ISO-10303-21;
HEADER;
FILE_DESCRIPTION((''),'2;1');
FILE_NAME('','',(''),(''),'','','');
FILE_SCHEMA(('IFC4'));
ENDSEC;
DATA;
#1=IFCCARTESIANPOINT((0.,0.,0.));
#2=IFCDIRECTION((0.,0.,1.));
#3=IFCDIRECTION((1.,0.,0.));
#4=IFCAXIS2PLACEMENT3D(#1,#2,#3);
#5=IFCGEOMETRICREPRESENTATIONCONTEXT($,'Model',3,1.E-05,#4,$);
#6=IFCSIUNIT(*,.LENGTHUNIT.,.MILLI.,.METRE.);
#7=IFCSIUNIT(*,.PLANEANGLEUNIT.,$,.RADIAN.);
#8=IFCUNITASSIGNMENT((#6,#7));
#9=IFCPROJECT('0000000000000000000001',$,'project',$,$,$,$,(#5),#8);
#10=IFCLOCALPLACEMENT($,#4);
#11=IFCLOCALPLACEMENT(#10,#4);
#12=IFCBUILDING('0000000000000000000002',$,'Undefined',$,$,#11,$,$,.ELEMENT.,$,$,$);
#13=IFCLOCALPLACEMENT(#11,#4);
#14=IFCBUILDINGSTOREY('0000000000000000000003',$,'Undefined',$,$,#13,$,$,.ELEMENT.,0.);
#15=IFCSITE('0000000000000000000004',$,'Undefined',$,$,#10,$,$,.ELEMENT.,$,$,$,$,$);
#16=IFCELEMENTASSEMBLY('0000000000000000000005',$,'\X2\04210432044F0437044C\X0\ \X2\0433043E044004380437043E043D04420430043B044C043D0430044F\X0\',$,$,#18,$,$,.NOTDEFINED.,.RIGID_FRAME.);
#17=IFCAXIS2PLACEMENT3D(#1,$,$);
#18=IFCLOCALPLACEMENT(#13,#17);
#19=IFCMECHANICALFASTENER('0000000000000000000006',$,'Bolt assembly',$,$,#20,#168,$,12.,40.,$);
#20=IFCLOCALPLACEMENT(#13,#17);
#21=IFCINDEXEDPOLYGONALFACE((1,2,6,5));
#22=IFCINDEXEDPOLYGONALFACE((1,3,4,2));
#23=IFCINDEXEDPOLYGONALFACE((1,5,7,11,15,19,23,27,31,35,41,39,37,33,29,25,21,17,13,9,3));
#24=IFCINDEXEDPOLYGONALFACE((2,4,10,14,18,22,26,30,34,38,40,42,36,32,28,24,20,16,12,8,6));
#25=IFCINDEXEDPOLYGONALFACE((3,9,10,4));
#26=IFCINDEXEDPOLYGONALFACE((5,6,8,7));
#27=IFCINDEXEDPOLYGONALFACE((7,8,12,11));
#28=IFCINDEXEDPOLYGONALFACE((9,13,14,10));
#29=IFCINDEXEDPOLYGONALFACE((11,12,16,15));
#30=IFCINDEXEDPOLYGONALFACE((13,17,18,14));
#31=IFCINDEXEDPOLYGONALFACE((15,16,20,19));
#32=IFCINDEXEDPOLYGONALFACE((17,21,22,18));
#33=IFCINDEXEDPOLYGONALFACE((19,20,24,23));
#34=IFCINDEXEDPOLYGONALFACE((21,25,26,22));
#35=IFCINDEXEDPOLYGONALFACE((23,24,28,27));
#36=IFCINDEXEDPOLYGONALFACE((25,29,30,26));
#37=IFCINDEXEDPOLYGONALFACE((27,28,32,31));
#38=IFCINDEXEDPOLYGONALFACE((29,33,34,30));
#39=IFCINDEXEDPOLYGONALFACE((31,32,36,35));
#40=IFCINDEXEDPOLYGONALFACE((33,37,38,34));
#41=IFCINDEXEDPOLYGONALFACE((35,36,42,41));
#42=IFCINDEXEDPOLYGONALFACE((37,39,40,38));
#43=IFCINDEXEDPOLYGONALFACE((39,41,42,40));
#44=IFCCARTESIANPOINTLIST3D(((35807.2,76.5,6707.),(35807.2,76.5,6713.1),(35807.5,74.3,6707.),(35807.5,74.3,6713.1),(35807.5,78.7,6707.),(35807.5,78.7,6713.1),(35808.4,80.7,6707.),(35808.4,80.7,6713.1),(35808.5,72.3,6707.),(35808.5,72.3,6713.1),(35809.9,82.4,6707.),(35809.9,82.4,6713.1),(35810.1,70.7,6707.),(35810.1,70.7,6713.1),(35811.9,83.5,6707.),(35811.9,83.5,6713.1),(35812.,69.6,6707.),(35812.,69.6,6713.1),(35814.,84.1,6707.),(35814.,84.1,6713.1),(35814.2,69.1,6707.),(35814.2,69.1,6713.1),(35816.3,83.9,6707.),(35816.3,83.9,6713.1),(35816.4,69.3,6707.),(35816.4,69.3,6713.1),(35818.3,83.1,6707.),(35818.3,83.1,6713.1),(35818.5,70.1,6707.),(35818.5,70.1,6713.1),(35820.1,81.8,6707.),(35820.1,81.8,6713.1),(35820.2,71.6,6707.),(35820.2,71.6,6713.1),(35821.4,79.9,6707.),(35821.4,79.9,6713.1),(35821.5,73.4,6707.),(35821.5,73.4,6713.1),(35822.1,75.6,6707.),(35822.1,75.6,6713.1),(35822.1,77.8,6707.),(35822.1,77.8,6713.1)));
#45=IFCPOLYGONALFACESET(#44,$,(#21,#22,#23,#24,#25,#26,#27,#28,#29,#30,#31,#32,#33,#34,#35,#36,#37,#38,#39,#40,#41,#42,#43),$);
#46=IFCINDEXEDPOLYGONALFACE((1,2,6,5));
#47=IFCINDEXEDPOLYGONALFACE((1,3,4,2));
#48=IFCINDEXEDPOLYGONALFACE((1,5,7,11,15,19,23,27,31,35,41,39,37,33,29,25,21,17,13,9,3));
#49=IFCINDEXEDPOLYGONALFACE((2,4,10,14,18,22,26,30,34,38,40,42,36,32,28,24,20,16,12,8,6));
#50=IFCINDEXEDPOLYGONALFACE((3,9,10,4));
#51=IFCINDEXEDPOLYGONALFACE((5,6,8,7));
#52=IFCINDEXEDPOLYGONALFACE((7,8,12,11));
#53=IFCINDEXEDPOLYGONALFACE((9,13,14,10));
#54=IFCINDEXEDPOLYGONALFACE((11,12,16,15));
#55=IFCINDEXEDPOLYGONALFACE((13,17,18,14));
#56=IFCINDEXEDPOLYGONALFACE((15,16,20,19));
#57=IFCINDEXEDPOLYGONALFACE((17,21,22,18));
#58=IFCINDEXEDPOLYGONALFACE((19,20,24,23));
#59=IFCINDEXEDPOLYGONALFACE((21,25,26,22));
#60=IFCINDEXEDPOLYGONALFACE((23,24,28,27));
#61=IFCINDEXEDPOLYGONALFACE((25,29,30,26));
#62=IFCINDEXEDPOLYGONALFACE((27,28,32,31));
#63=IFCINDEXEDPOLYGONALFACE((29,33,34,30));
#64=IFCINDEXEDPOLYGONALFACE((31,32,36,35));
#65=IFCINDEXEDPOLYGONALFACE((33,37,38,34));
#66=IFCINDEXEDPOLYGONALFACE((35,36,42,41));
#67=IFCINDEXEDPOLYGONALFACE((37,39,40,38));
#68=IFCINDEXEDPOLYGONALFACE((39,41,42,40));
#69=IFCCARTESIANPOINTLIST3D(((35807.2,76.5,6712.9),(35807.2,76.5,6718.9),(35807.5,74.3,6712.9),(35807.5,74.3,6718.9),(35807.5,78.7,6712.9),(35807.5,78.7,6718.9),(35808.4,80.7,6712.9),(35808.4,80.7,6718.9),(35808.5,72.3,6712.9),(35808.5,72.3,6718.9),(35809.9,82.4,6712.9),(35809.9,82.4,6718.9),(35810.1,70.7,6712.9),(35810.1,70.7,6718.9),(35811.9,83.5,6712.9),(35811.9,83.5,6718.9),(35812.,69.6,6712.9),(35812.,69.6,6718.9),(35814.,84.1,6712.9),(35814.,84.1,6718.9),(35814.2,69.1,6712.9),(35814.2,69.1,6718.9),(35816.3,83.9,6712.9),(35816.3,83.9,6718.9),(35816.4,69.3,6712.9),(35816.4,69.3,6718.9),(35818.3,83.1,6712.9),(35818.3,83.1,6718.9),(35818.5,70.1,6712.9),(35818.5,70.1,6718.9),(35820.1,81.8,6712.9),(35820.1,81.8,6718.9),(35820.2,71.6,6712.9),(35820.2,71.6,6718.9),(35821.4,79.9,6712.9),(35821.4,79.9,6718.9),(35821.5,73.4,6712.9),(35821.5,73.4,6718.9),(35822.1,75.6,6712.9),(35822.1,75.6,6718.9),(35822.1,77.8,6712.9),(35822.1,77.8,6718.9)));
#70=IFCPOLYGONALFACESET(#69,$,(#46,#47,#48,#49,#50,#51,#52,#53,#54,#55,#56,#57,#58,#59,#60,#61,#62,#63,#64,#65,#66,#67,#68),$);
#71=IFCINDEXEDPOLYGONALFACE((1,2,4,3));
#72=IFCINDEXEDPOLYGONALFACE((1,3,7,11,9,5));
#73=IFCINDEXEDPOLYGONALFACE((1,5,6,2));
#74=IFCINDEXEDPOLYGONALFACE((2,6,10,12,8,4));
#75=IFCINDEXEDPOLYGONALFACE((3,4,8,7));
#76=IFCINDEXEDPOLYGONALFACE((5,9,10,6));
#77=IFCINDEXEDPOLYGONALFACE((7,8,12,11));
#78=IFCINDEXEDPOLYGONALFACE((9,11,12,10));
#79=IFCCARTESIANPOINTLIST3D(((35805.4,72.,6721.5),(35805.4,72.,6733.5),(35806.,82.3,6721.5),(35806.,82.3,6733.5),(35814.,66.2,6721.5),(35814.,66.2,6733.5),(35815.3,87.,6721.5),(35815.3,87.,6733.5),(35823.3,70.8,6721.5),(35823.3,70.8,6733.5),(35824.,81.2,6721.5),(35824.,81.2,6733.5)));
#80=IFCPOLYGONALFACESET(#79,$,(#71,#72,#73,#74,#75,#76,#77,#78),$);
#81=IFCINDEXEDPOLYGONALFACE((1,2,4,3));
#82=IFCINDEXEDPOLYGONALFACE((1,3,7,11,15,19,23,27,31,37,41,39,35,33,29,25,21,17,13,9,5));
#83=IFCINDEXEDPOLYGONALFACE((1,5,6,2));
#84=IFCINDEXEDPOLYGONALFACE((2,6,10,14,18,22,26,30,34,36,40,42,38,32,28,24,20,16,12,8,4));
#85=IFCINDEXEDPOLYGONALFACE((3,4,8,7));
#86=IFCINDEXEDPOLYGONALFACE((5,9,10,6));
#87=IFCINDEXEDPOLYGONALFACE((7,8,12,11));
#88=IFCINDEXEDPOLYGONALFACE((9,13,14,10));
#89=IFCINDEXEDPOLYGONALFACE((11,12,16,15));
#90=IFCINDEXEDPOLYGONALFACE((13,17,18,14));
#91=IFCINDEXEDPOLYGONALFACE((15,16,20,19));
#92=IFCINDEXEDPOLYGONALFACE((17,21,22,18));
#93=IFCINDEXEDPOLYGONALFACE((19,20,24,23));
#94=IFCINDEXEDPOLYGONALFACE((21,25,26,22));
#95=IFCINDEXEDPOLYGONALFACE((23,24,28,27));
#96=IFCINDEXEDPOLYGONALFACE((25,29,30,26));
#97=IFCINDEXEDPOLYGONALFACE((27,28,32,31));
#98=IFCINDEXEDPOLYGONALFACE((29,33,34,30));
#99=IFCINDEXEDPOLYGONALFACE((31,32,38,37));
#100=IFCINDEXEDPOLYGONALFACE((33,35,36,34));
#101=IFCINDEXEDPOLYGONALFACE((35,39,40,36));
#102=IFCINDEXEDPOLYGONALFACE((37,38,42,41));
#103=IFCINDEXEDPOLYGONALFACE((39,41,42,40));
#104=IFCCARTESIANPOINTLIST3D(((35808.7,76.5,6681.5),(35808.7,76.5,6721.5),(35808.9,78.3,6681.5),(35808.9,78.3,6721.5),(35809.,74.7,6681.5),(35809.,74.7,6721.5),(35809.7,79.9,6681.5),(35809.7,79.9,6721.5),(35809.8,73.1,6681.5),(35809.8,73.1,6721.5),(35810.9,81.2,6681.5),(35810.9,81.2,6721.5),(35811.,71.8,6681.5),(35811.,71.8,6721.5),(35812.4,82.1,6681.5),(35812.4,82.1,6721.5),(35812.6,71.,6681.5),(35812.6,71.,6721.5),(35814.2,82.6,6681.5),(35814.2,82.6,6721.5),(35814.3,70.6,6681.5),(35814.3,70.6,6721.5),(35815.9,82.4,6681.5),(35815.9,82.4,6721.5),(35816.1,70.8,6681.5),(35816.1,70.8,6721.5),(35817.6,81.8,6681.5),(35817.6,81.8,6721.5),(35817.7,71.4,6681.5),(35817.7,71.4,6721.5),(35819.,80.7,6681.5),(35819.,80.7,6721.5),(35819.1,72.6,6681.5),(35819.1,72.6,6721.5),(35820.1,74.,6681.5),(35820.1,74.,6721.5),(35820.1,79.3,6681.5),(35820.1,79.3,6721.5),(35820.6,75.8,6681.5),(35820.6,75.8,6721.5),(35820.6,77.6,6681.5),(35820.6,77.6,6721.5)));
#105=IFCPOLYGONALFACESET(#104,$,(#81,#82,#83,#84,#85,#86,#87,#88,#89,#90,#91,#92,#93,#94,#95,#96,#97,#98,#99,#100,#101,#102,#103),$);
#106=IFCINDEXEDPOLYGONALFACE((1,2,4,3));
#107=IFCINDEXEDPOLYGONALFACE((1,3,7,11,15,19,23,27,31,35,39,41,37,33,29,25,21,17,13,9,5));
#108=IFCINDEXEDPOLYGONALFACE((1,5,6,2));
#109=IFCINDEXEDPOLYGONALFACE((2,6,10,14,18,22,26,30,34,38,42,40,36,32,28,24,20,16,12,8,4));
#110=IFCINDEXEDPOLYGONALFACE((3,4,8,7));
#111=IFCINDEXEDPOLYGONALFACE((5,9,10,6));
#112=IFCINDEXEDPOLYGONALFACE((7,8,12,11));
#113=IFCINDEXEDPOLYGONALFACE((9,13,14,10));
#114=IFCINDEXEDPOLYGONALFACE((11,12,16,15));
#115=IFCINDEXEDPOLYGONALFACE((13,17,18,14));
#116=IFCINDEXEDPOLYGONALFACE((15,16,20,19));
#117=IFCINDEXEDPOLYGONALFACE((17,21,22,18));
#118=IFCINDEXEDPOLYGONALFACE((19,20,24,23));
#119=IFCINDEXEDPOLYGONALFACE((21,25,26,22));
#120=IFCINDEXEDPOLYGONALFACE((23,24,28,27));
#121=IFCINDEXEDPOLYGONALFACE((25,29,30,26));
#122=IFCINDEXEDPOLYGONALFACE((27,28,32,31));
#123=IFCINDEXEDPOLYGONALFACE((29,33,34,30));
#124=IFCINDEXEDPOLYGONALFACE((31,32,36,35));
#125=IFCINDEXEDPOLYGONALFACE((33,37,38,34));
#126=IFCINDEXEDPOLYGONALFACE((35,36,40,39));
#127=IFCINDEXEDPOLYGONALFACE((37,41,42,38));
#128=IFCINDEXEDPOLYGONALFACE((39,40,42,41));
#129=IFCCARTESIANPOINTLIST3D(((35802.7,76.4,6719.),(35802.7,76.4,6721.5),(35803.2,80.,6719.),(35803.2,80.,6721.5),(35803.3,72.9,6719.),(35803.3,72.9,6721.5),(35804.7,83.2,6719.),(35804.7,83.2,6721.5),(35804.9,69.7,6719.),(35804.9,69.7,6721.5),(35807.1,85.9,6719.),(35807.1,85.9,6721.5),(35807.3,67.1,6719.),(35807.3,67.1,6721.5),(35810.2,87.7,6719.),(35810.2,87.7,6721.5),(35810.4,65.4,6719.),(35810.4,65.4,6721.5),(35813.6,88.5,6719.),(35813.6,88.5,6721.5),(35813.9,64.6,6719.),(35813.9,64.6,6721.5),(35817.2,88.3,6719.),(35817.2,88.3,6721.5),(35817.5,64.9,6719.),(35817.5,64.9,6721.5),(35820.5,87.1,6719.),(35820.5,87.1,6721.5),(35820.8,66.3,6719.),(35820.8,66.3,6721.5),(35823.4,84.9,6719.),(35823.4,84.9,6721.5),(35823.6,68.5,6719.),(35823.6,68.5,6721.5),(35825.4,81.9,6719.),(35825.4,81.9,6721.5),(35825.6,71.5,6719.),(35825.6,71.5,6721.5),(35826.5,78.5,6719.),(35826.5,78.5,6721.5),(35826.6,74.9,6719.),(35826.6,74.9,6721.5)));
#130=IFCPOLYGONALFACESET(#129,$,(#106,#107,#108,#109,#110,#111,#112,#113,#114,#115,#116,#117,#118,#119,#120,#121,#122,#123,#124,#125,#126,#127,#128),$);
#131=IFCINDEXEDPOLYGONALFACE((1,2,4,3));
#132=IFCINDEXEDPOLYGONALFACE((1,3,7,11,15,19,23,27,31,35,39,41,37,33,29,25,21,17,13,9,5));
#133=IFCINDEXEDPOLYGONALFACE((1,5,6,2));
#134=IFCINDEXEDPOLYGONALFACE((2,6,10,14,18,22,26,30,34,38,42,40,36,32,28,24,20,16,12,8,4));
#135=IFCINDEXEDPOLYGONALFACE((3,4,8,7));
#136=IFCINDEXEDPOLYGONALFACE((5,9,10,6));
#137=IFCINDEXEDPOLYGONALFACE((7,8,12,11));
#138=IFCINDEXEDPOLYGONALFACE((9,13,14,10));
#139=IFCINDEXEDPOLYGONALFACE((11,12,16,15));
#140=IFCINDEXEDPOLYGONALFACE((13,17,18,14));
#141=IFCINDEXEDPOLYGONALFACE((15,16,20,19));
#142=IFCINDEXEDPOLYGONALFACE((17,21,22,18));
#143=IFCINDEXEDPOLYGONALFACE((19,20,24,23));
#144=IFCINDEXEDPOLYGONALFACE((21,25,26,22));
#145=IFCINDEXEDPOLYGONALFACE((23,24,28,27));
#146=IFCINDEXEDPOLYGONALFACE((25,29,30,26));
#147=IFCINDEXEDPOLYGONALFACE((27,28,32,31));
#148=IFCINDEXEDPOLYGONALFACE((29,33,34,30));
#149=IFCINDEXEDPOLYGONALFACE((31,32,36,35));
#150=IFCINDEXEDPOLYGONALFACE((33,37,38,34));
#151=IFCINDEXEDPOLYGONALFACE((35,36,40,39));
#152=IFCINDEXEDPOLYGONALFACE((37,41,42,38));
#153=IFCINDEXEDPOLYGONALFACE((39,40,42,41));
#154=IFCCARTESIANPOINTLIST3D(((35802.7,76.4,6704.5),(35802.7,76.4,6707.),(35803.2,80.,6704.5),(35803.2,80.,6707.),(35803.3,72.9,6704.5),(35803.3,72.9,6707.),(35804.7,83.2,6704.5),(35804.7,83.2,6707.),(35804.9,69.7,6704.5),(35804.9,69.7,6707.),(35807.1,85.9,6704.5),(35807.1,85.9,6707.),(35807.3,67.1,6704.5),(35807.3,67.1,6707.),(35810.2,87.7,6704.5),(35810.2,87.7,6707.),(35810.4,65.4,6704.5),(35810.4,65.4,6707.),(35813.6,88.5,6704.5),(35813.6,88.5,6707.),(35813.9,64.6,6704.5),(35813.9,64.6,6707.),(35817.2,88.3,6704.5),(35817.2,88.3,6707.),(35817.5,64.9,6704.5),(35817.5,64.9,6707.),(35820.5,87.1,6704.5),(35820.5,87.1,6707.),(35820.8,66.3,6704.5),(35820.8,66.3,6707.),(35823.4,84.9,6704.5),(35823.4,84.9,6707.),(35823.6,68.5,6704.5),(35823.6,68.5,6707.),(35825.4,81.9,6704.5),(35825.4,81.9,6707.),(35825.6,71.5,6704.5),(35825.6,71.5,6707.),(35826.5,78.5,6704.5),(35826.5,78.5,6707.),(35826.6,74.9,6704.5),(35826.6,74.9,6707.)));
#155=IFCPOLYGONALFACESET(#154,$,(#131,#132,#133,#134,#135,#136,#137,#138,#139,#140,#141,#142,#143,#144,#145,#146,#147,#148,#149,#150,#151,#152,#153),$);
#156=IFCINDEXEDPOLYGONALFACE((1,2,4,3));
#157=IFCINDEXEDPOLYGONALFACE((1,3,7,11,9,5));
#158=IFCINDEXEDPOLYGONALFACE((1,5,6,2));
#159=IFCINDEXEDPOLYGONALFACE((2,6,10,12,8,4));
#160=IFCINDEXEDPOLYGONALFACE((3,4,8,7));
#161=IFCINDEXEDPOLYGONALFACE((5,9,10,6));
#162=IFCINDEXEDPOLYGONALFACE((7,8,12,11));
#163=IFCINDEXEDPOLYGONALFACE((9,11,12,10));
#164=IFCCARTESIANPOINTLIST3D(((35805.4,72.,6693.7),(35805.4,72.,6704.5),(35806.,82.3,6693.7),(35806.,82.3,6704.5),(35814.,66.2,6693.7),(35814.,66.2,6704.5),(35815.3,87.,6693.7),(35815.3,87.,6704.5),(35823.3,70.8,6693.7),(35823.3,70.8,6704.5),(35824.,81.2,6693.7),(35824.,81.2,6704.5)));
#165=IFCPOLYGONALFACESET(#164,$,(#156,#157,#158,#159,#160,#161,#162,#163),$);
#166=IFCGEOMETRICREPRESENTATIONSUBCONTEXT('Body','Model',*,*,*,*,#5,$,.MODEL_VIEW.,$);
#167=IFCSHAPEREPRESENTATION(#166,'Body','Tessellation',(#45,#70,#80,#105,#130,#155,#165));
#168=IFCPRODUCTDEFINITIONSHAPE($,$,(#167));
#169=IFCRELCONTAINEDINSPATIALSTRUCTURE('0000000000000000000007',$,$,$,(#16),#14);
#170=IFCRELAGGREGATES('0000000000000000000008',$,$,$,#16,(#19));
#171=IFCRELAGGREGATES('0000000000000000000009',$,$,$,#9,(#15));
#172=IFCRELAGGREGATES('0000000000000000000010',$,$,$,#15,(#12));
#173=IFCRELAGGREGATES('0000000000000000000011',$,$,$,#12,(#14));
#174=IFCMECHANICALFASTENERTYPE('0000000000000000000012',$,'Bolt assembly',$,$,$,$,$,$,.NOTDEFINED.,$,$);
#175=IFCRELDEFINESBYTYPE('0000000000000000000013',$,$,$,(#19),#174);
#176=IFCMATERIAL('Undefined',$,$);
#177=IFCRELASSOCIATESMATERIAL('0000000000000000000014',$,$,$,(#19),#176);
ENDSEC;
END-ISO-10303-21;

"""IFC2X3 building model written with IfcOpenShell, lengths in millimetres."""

from ifc_helpers import new_model, si_unit, frame, origin_with_axes, origin_2d_with_axis, place, context, subcontext, project, spatial, polyline, circle, outline, extrude, source, transform, mapped, material, type_object, element, aggregate, save


model = new_model("IFC2X3")

# Units and contexts
model_context = context("Model", 3, precision=1e-05, world=origin_with_axes())
body_context = subcontext(model_context, "Body", "Model", "MODEL_VIEW")
ifc_project = project(units=[si_unit("LENGTHUNIT", "METRE", prefix="MILLI"), si_unit("PLANEANGLEUNIT", "RADIAN")], contexts=[model_context])

# Site, building, storey
site_placement = place(None, origin_with_axes())
site = spatial("IfcSite", under=ifc_project, at=site_placement, Name="Undefined", CompositionType="ELEMENT")
building_placement = place(site_placement, origin_with_axes())
building = spatial("IfcBuilding", under=site, at=building_placement, Name="Undefined", CompositionType="ELEMENT")
storey_placement = place(building_placement, origin_with_axes())
storey = spatial("IfcBuildingStorey", under=building, at=storey_placement, Name="Undefined", CompositionType="ELEMENT", Elevation=0.0)

# Element assembly
assembly_1_placement = place(storey_placement, origin_with_axes())
assembly_1 = element("IfcElementAssembly", 1, at=assembly_1_placement, inside=storey, Name="Связь горизонтальная", AssemblyPlace="NOTDEFINED", PredefinedType="RIGID_FRAME")

# Mechanical fastener
ifc_material_1 = material(Name="Undefined")
mechanical_fastener_type = type_object("IfcMechanicalFastenerType", Name="Bolt assembly")
shared_shape_1 = source(origin_with_axes(), body_context, "Body", "SweptSolid", [
    extrude(circle(Radius=7.5, at=origin_2d_with_axis()), frame((0.0, -0.1, 0.0), z_axis=(0.0, 1.0, 0.0), x_axis=(1.0, 0.0, 0.0)), (0.0, 0.0, 1.0), 6.1),
    extrude(circle(Radius=7.5, at=origin_2d_with_axis()), frame((0.0, -5.9, 0.0), z_axis=(0.0, 1.0, 0.0), x_axis=(1.0, 0.0, 0.0)), (0.0, 0.0, 1.0), 6.0),
    extrude(outline(polyline([(10.4, 0.0), (5.2, 9.0), (-5.2, 9.0), (-10.4, 0.0), (-5.2, -9.0), (5.2, -9.0), (10.4, 0.0)])), frame((0.0, -20.5, 0.0), z_axis=(0.0, 1.0, 0.0), x_axis=(1.0, 0.0, 0.0)), (0.0, 0.0, 1.0), 12.0),
    extrude(circle(Radius=6.0, at=origin_2d_with_axis()), frame((0.0, -8.5, 0.0), z_axis=(0.0, 1.0, 0.0), x_axis=(1.0, 0.0, 0.0)), (0.0, 0.0, 1.0), 40.0),
    extrude(circle(Radius=12.0, at=origin_2d_with_axis()), frame((0.0, -8.5, 0.0), z_axis=(0.0, 1.0, 0.0), x_axis=(1.0, 0.0, 0.0)), (0.0, 0.0, 1.0), 2.5),
    extrude(circle(Radius=12.0, at=origin_2d_with_axis()), frame((0.0, 6.0, 0.0), z_axis=(0.0, 1.0, 0.0), x_axis=(1.0, 0.0, 0.0)), (0.0, 0.0, 1.0), 2.5),
    extrude(outline(polyline([(10.4, 0.0), (5.2, 9.0), (-5.2, 9.0), (-10.4, 0.0), (-5.2, -9.0), (5.2, -9.0), (10.4, 0.0)])), frame((0.0, 8.5, 0.0), z_axis=(0.0, 1.0, 0.0), x_axis=(1.0, 0.0, 0.0)), (0.0, 0.0, 1.0), 10.8),
])
mechanical_fastener_1_placement = place(assembly_1_placement, frame((35814.7, 76.6, 6713.0), z_axis=(-0.552695, -0.833383, 0.0), x_axis=(-0.833383, 0.552695, 0.0)))
mechanical_fastener_1 = element("IfcMechanicalFastener", 2, at=mechanical_fastener_1_placement, type_object=mechanical_fastener_type, material=ifc_material_1, Name="Bolt assembly", NominalDiameter=12.0, NominalLength=40.0, context=body_context, shape_type="MappedRepresentation", body=[
    mapped(shared_shape_1, transform((0.0, 0.0, 0.0))),
])
aggregate(assembly_1, [mechanical_fastener_1])

save(model, "model.ifc")
